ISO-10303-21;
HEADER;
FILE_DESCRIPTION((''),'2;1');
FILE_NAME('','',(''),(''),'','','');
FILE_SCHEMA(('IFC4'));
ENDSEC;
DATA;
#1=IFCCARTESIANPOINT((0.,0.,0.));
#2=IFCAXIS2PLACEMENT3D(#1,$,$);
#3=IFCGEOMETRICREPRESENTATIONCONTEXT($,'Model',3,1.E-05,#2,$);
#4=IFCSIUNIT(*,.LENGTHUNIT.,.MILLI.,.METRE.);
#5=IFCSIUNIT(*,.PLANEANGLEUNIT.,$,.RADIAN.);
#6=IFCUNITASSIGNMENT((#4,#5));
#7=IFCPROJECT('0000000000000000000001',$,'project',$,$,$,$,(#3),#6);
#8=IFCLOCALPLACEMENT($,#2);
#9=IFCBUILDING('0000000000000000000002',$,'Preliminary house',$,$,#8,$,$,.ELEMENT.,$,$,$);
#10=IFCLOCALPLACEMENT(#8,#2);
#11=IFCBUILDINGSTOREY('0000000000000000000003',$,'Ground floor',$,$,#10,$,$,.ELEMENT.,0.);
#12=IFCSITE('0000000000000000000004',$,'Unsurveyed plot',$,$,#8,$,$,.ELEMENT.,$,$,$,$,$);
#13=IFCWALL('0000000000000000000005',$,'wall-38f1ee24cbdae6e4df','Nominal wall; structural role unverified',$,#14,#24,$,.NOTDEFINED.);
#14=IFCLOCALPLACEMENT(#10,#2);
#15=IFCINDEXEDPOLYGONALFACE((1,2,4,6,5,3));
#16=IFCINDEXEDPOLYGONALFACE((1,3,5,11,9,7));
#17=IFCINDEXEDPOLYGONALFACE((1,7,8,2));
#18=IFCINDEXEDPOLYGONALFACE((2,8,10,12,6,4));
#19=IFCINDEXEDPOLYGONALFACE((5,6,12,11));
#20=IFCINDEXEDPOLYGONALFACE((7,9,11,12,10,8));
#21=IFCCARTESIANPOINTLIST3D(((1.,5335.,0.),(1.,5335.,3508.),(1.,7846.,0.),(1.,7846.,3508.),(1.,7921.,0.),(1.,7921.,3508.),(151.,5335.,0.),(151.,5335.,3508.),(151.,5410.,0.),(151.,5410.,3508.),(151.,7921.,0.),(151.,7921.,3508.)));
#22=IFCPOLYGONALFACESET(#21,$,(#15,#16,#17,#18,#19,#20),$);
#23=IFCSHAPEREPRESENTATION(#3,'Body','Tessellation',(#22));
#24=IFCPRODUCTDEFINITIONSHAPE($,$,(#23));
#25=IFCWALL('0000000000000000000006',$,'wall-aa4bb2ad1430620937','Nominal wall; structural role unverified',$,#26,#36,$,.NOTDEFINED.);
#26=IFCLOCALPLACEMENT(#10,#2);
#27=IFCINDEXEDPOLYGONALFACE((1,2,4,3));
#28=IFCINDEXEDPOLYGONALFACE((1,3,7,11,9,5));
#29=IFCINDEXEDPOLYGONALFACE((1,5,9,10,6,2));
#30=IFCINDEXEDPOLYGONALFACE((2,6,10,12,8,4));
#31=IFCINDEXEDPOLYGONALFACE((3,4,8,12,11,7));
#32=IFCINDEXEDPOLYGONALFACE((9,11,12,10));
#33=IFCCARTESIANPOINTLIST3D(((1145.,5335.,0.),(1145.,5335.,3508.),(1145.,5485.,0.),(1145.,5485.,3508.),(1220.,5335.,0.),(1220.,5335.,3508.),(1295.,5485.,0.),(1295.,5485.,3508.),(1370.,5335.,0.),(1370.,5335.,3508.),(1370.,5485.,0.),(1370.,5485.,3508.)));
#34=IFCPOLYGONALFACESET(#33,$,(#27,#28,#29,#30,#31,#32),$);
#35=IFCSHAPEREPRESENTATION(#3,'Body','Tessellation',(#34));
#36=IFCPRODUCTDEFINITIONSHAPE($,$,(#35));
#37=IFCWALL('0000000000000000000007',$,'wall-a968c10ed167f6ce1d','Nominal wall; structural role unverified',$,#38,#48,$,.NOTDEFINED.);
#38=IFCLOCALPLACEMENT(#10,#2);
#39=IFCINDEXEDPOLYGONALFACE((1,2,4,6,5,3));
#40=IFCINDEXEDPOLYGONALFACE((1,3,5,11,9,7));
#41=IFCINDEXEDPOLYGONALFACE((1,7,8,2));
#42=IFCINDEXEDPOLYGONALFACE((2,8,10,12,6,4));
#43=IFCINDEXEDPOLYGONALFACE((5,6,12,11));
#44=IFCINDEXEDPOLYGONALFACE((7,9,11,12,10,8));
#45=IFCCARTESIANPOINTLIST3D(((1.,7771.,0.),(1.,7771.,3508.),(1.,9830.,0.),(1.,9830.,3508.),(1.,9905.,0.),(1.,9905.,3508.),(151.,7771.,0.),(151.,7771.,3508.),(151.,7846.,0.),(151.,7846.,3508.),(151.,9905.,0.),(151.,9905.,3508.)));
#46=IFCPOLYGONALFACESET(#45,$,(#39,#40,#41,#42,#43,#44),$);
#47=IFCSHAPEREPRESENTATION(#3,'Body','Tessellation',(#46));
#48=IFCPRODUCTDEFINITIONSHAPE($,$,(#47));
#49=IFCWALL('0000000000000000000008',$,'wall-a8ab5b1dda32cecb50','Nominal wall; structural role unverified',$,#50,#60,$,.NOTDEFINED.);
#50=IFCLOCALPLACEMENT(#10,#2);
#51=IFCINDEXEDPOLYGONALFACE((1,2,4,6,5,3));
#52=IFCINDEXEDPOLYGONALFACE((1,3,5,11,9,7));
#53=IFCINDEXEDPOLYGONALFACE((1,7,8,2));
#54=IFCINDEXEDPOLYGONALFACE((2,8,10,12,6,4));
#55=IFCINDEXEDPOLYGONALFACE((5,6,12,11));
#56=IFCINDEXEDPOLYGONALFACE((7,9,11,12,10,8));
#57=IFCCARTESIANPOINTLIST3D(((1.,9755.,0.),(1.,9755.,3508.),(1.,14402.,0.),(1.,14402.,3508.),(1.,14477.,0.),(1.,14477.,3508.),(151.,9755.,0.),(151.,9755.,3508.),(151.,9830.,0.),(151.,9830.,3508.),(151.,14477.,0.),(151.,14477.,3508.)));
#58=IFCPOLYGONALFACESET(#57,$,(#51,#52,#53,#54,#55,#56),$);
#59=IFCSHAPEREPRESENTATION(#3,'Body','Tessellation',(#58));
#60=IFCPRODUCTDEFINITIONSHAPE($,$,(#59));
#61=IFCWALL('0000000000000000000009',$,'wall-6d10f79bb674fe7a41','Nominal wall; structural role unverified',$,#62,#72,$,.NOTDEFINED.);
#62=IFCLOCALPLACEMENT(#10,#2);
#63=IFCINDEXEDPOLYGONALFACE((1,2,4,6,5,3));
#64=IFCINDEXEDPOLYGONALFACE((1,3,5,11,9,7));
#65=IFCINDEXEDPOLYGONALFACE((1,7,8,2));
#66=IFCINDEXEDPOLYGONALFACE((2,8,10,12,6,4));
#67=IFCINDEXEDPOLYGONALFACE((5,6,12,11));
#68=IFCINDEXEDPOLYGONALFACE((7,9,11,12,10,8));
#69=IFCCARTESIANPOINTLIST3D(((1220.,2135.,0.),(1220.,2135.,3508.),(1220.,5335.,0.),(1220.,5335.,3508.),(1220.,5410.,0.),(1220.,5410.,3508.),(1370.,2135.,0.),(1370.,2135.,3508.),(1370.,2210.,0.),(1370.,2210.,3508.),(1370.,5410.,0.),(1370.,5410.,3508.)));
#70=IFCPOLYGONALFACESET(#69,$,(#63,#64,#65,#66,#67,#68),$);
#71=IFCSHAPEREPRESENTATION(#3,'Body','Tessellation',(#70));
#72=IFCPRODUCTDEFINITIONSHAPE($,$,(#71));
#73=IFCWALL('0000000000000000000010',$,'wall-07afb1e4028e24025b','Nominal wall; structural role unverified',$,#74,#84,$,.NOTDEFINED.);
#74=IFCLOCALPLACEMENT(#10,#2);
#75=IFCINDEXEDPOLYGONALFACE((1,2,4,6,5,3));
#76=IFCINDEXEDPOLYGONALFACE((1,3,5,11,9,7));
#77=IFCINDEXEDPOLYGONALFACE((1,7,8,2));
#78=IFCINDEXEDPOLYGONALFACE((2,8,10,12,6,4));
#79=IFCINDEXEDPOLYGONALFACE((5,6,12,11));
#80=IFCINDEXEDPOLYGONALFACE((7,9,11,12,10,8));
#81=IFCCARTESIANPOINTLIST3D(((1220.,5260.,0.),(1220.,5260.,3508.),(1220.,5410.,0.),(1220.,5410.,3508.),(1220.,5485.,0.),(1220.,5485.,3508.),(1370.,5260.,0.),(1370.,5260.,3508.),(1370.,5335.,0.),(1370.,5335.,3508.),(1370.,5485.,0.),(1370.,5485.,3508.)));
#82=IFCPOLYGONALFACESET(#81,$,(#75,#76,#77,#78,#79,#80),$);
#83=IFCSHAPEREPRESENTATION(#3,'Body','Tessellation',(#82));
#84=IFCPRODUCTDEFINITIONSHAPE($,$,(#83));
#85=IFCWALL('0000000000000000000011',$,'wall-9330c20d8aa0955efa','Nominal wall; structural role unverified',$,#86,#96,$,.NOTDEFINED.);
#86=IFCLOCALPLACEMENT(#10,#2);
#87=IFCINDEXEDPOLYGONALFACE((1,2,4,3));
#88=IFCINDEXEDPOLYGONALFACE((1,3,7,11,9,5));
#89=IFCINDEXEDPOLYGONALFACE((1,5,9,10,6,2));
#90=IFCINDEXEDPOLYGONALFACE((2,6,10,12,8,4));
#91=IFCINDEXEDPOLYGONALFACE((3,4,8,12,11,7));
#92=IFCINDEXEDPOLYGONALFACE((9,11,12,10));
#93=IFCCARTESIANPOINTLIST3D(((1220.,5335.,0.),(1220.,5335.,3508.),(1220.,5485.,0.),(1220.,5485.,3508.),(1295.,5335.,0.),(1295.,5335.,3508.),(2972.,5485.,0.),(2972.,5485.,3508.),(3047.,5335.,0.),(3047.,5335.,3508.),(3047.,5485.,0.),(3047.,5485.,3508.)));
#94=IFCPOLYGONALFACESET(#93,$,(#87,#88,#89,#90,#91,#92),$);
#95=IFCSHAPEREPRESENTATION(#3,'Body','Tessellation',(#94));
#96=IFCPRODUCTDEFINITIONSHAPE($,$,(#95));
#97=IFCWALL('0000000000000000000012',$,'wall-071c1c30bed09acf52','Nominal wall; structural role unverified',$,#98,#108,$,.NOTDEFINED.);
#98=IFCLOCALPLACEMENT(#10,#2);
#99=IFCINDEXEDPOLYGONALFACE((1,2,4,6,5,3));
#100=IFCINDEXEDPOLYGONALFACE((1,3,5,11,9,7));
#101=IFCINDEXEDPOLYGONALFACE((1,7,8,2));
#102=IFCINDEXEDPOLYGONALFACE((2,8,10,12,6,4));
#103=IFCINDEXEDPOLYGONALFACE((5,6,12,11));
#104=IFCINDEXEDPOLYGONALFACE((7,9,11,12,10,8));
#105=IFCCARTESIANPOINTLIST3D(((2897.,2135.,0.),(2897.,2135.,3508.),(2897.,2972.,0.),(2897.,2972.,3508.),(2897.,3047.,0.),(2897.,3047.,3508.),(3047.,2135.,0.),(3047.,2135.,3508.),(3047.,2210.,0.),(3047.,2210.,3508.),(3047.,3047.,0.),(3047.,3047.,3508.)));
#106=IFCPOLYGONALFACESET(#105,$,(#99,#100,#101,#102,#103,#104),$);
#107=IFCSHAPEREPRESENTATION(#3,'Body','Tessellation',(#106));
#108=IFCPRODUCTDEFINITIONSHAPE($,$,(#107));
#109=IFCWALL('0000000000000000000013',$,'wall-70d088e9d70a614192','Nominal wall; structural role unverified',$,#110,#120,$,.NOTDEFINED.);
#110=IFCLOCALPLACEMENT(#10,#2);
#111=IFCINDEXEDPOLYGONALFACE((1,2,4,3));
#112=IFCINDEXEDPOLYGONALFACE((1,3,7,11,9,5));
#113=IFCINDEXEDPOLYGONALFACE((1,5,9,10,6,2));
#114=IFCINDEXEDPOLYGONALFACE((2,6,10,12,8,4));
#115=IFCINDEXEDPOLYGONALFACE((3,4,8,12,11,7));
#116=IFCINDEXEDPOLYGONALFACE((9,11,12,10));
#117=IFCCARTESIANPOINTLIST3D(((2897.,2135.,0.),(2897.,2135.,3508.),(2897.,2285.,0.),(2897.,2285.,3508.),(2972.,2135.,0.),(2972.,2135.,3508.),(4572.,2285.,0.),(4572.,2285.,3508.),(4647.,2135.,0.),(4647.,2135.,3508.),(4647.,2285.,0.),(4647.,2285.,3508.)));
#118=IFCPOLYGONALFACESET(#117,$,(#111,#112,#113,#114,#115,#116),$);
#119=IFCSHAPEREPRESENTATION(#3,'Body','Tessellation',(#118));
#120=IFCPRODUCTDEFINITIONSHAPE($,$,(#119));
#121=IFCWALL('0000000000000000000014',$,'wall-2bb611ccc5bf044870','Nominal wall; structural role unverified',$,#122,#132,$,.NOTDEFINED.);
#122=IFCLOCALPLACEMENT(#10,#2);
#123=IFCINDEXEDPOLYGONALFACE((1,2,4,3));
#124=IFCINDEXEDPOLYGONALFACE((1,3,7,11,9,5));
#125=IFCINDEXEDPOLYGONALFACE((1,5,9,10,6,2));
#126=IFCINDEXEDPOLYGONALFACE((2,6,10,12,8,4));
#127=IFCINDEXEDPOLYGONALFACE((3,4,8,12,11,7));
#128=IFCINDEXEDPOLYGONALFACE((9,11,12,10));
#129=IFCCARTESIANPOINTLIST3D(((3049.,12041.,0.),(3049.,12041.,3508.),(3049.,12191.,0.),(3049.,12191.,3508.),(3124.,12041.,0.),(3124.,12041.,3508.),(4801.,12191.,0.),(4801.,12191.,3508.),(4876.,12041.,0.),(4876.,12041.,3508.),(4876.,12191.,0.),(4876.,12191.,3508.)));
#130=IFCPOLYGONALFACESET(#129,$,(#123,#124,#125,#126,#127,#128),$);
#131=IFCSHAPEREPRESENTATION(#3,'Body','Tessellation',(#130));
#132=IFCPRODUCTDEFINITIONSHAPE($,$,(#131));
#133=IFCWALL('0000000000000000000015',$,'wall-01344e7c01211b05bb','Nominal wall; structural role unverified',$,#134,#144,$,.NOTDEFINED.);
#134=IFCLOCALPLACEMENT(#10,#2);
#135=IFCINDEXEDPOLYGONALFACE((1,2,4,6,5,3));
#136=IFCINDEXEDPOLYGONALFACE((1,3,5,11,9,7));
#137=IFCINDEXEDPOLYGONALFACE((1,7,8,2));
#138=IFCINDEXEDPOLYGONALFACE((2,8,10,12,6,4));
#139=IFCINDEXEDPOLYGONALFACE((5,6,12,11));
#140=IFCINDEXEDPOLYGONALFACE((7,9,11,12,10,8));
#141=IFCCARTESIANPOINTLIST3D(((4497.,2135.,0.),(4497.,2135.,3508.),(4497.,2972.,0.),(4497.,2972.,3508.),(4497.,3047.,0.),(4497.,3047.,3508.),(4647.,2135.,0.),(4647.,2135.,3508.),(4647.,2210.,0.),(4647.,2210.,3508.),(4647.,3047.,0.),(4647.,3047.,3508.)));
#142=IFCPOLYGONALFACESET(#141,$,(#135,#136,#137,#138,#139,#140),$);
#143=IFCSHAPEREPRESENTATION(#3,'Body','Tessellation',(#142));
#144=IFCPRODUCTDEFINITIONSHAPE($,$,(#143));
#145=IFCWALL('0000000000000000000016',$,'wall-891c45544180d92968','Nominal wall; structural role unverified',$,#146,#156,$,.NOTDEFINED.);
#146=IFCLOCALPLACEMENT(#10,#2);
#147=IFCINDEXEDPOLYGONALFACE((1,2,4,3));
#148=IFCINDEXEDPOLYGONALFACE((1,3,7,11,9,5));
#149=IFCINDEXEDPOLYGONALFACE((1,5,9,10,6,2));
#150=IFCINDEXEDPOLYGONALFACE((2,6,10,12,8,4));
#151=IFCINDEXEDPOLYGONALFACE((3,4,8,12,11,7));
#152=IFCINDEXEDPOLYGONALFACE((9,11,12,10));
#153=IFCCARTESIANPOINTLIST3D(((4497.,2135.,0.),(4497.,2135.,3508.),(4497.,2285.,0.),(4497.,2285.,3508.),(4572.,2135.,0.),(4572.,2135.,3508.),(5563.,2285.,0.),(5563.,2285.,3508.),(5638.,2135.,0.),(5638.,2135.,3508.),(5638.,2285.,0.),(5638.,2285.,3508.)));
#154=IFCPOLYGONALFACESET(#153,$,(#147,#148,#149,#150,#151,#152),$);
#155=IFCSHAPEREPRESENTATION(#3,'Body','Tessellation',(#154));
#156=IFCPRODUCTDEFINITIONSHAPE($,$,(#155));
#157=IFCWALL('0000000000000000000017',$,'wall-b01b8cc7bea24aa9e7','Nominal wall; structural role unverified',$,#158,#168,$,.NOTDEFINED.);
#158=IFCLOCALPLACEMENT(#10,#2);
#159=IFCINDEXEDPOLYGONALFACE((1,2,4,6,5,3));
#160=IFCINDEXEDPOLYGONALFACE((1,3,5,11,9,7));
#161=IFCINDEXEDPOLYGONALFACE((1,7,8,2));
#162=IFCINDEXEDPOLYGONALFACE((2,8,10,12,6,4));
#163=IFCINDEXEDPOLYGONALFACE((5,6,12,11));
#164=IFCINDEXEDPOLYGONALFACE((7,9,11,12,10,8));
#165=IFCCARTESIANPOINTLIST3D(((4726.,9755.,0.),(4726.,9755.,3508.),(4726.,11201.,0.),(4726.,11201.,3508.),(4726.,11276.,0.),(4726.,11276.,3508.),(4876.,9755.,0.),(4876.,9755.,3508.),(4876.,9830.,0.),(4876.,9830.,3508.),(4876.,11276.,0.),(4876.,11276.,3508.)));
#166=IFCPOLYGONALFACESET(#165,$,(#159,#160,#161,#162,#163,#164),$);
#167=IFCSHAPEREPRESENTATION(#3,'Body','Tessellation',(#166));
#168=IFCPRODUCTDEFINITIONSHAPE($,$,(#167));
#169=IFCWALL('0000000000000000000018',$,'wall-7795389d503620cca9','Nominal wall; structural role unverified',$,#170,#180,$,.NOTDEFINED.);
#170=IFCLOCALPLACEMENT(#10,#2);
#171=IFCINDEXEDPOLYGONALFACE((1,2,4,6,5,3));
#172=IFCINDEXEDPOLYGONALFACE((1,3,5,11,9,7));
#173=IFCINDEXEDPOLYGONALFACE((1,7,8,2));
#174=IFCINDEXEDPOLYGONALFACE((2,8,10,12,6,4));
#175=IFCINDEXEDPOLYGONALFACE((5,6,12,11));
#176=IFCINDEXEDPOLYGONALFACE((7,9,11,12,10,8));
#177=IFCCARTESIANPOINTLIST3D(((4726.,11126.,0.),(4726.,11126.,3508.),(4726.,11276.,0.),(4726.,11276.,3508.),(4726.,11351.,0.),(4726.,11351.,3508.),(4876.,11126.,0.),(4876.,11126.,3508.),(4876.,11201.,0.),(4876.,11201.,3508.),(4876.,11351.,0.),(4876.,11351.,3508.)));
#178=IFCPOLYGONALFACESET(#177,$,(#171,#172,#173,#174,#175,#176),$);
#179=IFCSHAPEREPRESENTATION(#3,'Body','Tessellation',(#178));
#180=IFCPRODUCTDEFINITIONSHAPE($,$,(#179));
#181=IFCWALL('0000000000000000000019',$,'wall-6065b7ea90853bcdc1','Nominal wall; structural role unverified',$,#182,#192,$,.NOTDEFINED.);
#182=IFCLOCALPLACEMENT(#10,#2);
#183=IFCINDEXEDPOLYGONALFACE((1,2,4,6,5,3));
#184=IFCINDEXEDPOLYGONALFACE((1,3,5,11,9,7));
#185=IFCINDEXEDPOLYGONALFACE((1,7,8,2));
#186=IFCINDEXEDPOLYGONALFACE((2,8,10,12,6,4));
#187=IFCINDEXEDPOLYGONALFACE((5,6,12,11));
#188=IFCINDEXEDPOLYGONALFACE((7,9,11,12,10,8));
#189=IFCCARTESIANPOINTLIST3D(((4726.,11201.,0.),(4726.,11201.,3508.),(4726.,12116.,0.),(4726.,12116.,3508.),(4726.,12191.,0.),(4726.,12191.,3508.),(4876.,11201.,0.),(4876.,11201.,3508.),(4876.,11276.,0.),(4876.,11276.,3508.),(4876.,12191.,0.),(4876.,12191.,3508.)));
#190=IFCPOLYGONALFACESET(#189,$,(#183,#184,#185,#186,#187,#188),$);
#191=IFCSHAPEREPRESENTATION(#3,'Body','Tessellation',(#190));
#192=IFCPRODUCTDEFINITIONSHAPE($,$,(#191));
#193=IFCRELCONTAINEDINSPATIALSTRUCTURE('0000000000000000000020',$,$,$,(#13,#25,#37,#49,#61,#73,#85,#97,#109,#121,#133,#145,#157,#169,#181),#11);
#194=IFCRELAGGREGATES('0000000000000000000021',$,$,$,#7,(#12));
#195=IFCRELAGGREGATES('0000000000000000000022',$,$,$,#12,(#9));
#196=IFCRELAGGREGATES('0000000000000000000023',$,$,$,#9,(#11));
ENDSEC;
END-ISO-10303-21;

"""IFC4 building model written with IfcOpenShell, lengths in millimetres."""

from ifc_helpers import new_model, si_unit, origin, place, context, project, spatial, polyline, outline, extrude, element, save


model = new_model("IFC4")

# Units and contexts
model_context = context("Model", 3, precision=1e-05, world=origin())
ifc_project = project(units=[si_unit("LENGTHUNIT", "METRE", prefix="MILLI"), si_unit("PLANEANGLEUNIT", "RADIAN")], contexts=[model_context])

# Site, building, storey
placement_1 = place(None, origin())
site = spatial("IfcSite", under=ifc_project, at=placement_1, Name="Unsurveyed plot", CompositionType="ELEMENT")
building = spatial("IfcBuilding", under=site, at=placement_1, Name="Preliminary house", CompositionType="ELEMENT")
placement_2 = place(placement_1, origin())
storey = spatial("IfcBuildingStorey", under=building, at=placement_2, Name="Ground floor", CompositionType="ELEMENT", Elevation=0.0)

# Wall
element("IfcWall", 1, at=placement_2, inside=storey, Name="wall-38f1ee24cbdae6e4df", Description="Nominal wall; structural role unverified", PredefinedType="NOTDEFINED", context=model_context, shape_type="SweptSolid", body=[
    extrude(outline(polyline([(1.0, 7846.0), (1.0, 7921.0), (151.0, 7921.0), (151.0, 5410.0), (151.0, 5335.0), (1.0, 5335.0), (1.0, 7846.0)])), origin(), (0.0, 0.0, 1.0), 3508.0),
])

# Walls
element("IfcWall", 2, at=placement_2, inside=storey, Name="wall-aa4bb2ad1430620937", Description="Nominal wall; structural role unverified", PredefinedType="NOTDEFINED", context=model_context, shape_type="SweptSolid", body=[
    extrude(outline(polyline([(1295.0, 5485.0), (1370.0, 5485.0), (1370.0, 5335.0), (1220.0, 5335.0), (1145.0, 5335.0), (1145.0, 5485.0), (1295.0, 5485.0)])), origin(), (0.0, 0.0, 1.0), 3508.0),
])
element("IfcWall", 3, at=placement_2, inside=storey, Name="wall-a968c10ed167f6ce1d", Description="Nominal wall; structural role unverified", PredefinedType="NOTDEFINED", context=model_context, shape_type="SweptSolid", body=[
    extrude(outline(polyline([(1.0, 9830.0), (1.0, 9905.0), (151.0, 9905.0), (151.0, 7846.0), (151.0, 7771.0), (1.0, 7771.0), (1.0, 9830.0)])), origin(), (0.0, 0.0, 1.0), 3508.0),
])

# Wall
element("IfcWall", 4, at=placement_2, inside=storey, Name="wall-a8ab5b1dda32cecb50", Description="Nominal wall; structural role unverified", PredefinedType="NOTDEFINED", context=model_context, shape_type="SweptSolid", body=[
    extrude(outline(polyline([(1.0, 14402.0), (1.0, 14477.0), (151.0, 14477.0), (151.0, 9830.0), (151.0, 9755.0), (1.0, 9755.0), (1.0, 14402.0)])), origin(), (0.0, 0.0, 1.0), 3508.0),
])

# Walls
element("IfcWall", 5, at=placement_2, inside=storey, Name="wall-6d10f79bb674fe7a41", Description="Nominal wall; structural role unverified", PredefinedType="NOTDEFINED", context=model_context, shape_type="SweptSolid", body=[
    extrude(outline(polyline([(1220.0, 5335.0), (1220.0, 5410.0), (1370.0, 5410.0), (1370.0, 2210.0), (1370.0, 2135.0), (1220.0, 2135.0), (1220.0, 5335.0)])), origin(), (0.0, 0.0, 1.0), 3508.0),
])
element("IfcWall", 6, at=placement_2, inside=storey, Name="wall-07afb1e4028e24025b", Description="Nominal wall; structural role unverified", PredefinedType="NOTDEFINED", context=model_context, shape_type="SweptSolid", body=[
    extrude(outline(polyline([(1220.0, 5410.0), (1220.0, 5485.0), (1370.0, 5485.0), (1370.0, 5335.0), (1370.0, 5260.0), (1220.0, 5260.0), (1220.0, 5410.0)])), origin(), (0.0, 0.0, 1.0), 3508.0),
])

# Walls
element("IfcWall", 7, at=placement_2, inside=storey, Name="wall-9330c20d8aa0955efa", Description="Nominal wall; structural role unverified", PredefinedType="NOTDEFINED", context=model_context, shape_type="SweptSolid", body=[
    extrude(outline(polyline([(2972.0, 5485.0), (3047.0, 5485.0), (3047.0, 5335.0), (1295.0, 5335.0), (1220.0, 5335.0), (1220.0, 5485.0), (2972.0, 5485.0)])), origin(), (0.0, 0.0, 1.0), 3508.0),
])
element("IfcWall", 8, at=placement_2, inside=storey, Name="wall-071c1c30bed09acf52", Description="Nominal wall; structural role unverified", PredefinedType="NOTDEFINED", context=model_context, shape_type="SweptSolid", body=[
    extrude(outline(polyline([(2897.0, 2972.0), (2897.0, 3047.0), (3047.0, 3047.0), (3047.0, 2210.0), (3047.0, 2135.0), (2897.0, 2135.0), (2897.0, 2972.0)])), origin(), (0.0, 0.0, 1.0), 3508.0),
])
element("IfcWall", 9, at=placement_2, inside=storey, Name="wall-70d088e9d70a614192", Description="Nominal wall; structural role unverified", PredefinedType="NOTDEFINED", context=model_context, shape_type="SweptSolid", body=[
    extrude(outline(polyline([(4572.0, 2285.0), (4647.0, 2285.0), (4647.0, 2135.0), (2972.0, 2135.0), (2897.0, 2135.0), (2897.0, 2285.0), (4572.0, 2285.0)])), origin(), (0.0, 0.0, 1.0), 3508.0),
])

# Wall
element("IfcWall", 10, at=placement_2, inside=storey, Name="wall-2bb611ccc5bf044870", Description="Nominal wall; structural role unverified", PredefinedType="NOTDEFINED", context=model_context, shape_type="SweptSolid", body=[
    extrude(outline(polyline([(4801.0, 12191.0), (4876.0, 12191.0), (4876.0, 12041.0), (3124.0, 12041.0), (3049.0, 12041.0), (3049.0, 12191.0), (4801.0, 12191.0)])), origin(), (0.0, 0.0, 1.0), 3508.0),
])

# Walls
element("IfcWall", 11, at=placement_2, inside=storey, Name="wall-01344e7c01211b05bb", Description="Nominal wall; structural role unverified", PredefinedType="NOTDEFINED", context=model_context, shape_type="SweptSolid", body=[
    extrude(outline(polyline([(4497.0, 2972.0), (4497.0, 3047.0), (4647.0, 3047.0), (4647.0, 2210.0), (4647.0, 2135.0), (4497.0, 2135.0), (4497.0, 2972.0)])), origin(), (0.0, 0.0, 1.0), 3508.0),
])
element("IfcWall", 12, at=placement_2, inside=storey, Name="wall-891c45544180d92968", Description="Nominal wall; structural role unverified", PredefinedType="NOTDEFINED", context=model_context, shape_type="SweptSolid", body=[
    extrude(outline(polyline([(5563.0, 2285.0), (5638.0, 2285.0), (5638.0, 2135.0), (4572.0, 2135.0), (4497.0, 2135.0), (4497.0, 2285.0), (5563.0, 2285.0)])), origin(), (0.0, 0.0, 1.0), 3508.0),
])
element("IfcWall", 13, at=placement_2, inside=storey, Name="wall-b01b8cc7bea24aa9e7", Description="Nominal wall; structural role unverified", PredefinedType="NOTDEFINED", context=model_context, shape_type="SweptSolid", body=[
    extrude(outline(polyline([(4726.0, 11201.0), (4726.0, 11276.0), (4876.0, 11276.0), (4876.0, 9830.0), (4876.0, 9755.0), (4726.0, 9755.0), (4726.0, 11201.0)])), origin(), (0.0, 0.0, 1.0), 3508.0),
])

# Walls
element("IfcWall", 14, at=placement_2, inside=storey, Name="wall-7795389d503620cca9", Description="Nominal wall; structural role unverified", PredefinedType="NOTDEFINED", context=model_context, shape_type="SweptSolid", body=[
    extrude(outline(polyline([(4726.0, 11276.0), (4726.0, 11351.0), (4876.0, 11351.0), (4876.0, 11201.0), (4876.0, 11126.0), (4726.0, 11126.0), (4726.0, 11276.0)])), origin(), (0.0, 0.0, 1.0), 3508.0),
])
element("IfcWall", 15, at=placement_2, inside=storey, Name="wall-6065b7ea90853bcdc1", Description="Nominal wall; structural role unverified", PredefinedType="NOTDEFINED", context=model_context, shape_type="SweptSolid", body=[
    extrude(outline(polyline([(4726.0, 12116.0), (4726.0, 12191.0), (4876.0, 12191.0), (4876.0, 11276.0), (4876.0, 11201.0), (4726.0, 11201.0), (4726.0, 12116.0)])), origin(), (0.0, 0.0, 1.0), 3508.0),
])

save(model, "model.ifc")
